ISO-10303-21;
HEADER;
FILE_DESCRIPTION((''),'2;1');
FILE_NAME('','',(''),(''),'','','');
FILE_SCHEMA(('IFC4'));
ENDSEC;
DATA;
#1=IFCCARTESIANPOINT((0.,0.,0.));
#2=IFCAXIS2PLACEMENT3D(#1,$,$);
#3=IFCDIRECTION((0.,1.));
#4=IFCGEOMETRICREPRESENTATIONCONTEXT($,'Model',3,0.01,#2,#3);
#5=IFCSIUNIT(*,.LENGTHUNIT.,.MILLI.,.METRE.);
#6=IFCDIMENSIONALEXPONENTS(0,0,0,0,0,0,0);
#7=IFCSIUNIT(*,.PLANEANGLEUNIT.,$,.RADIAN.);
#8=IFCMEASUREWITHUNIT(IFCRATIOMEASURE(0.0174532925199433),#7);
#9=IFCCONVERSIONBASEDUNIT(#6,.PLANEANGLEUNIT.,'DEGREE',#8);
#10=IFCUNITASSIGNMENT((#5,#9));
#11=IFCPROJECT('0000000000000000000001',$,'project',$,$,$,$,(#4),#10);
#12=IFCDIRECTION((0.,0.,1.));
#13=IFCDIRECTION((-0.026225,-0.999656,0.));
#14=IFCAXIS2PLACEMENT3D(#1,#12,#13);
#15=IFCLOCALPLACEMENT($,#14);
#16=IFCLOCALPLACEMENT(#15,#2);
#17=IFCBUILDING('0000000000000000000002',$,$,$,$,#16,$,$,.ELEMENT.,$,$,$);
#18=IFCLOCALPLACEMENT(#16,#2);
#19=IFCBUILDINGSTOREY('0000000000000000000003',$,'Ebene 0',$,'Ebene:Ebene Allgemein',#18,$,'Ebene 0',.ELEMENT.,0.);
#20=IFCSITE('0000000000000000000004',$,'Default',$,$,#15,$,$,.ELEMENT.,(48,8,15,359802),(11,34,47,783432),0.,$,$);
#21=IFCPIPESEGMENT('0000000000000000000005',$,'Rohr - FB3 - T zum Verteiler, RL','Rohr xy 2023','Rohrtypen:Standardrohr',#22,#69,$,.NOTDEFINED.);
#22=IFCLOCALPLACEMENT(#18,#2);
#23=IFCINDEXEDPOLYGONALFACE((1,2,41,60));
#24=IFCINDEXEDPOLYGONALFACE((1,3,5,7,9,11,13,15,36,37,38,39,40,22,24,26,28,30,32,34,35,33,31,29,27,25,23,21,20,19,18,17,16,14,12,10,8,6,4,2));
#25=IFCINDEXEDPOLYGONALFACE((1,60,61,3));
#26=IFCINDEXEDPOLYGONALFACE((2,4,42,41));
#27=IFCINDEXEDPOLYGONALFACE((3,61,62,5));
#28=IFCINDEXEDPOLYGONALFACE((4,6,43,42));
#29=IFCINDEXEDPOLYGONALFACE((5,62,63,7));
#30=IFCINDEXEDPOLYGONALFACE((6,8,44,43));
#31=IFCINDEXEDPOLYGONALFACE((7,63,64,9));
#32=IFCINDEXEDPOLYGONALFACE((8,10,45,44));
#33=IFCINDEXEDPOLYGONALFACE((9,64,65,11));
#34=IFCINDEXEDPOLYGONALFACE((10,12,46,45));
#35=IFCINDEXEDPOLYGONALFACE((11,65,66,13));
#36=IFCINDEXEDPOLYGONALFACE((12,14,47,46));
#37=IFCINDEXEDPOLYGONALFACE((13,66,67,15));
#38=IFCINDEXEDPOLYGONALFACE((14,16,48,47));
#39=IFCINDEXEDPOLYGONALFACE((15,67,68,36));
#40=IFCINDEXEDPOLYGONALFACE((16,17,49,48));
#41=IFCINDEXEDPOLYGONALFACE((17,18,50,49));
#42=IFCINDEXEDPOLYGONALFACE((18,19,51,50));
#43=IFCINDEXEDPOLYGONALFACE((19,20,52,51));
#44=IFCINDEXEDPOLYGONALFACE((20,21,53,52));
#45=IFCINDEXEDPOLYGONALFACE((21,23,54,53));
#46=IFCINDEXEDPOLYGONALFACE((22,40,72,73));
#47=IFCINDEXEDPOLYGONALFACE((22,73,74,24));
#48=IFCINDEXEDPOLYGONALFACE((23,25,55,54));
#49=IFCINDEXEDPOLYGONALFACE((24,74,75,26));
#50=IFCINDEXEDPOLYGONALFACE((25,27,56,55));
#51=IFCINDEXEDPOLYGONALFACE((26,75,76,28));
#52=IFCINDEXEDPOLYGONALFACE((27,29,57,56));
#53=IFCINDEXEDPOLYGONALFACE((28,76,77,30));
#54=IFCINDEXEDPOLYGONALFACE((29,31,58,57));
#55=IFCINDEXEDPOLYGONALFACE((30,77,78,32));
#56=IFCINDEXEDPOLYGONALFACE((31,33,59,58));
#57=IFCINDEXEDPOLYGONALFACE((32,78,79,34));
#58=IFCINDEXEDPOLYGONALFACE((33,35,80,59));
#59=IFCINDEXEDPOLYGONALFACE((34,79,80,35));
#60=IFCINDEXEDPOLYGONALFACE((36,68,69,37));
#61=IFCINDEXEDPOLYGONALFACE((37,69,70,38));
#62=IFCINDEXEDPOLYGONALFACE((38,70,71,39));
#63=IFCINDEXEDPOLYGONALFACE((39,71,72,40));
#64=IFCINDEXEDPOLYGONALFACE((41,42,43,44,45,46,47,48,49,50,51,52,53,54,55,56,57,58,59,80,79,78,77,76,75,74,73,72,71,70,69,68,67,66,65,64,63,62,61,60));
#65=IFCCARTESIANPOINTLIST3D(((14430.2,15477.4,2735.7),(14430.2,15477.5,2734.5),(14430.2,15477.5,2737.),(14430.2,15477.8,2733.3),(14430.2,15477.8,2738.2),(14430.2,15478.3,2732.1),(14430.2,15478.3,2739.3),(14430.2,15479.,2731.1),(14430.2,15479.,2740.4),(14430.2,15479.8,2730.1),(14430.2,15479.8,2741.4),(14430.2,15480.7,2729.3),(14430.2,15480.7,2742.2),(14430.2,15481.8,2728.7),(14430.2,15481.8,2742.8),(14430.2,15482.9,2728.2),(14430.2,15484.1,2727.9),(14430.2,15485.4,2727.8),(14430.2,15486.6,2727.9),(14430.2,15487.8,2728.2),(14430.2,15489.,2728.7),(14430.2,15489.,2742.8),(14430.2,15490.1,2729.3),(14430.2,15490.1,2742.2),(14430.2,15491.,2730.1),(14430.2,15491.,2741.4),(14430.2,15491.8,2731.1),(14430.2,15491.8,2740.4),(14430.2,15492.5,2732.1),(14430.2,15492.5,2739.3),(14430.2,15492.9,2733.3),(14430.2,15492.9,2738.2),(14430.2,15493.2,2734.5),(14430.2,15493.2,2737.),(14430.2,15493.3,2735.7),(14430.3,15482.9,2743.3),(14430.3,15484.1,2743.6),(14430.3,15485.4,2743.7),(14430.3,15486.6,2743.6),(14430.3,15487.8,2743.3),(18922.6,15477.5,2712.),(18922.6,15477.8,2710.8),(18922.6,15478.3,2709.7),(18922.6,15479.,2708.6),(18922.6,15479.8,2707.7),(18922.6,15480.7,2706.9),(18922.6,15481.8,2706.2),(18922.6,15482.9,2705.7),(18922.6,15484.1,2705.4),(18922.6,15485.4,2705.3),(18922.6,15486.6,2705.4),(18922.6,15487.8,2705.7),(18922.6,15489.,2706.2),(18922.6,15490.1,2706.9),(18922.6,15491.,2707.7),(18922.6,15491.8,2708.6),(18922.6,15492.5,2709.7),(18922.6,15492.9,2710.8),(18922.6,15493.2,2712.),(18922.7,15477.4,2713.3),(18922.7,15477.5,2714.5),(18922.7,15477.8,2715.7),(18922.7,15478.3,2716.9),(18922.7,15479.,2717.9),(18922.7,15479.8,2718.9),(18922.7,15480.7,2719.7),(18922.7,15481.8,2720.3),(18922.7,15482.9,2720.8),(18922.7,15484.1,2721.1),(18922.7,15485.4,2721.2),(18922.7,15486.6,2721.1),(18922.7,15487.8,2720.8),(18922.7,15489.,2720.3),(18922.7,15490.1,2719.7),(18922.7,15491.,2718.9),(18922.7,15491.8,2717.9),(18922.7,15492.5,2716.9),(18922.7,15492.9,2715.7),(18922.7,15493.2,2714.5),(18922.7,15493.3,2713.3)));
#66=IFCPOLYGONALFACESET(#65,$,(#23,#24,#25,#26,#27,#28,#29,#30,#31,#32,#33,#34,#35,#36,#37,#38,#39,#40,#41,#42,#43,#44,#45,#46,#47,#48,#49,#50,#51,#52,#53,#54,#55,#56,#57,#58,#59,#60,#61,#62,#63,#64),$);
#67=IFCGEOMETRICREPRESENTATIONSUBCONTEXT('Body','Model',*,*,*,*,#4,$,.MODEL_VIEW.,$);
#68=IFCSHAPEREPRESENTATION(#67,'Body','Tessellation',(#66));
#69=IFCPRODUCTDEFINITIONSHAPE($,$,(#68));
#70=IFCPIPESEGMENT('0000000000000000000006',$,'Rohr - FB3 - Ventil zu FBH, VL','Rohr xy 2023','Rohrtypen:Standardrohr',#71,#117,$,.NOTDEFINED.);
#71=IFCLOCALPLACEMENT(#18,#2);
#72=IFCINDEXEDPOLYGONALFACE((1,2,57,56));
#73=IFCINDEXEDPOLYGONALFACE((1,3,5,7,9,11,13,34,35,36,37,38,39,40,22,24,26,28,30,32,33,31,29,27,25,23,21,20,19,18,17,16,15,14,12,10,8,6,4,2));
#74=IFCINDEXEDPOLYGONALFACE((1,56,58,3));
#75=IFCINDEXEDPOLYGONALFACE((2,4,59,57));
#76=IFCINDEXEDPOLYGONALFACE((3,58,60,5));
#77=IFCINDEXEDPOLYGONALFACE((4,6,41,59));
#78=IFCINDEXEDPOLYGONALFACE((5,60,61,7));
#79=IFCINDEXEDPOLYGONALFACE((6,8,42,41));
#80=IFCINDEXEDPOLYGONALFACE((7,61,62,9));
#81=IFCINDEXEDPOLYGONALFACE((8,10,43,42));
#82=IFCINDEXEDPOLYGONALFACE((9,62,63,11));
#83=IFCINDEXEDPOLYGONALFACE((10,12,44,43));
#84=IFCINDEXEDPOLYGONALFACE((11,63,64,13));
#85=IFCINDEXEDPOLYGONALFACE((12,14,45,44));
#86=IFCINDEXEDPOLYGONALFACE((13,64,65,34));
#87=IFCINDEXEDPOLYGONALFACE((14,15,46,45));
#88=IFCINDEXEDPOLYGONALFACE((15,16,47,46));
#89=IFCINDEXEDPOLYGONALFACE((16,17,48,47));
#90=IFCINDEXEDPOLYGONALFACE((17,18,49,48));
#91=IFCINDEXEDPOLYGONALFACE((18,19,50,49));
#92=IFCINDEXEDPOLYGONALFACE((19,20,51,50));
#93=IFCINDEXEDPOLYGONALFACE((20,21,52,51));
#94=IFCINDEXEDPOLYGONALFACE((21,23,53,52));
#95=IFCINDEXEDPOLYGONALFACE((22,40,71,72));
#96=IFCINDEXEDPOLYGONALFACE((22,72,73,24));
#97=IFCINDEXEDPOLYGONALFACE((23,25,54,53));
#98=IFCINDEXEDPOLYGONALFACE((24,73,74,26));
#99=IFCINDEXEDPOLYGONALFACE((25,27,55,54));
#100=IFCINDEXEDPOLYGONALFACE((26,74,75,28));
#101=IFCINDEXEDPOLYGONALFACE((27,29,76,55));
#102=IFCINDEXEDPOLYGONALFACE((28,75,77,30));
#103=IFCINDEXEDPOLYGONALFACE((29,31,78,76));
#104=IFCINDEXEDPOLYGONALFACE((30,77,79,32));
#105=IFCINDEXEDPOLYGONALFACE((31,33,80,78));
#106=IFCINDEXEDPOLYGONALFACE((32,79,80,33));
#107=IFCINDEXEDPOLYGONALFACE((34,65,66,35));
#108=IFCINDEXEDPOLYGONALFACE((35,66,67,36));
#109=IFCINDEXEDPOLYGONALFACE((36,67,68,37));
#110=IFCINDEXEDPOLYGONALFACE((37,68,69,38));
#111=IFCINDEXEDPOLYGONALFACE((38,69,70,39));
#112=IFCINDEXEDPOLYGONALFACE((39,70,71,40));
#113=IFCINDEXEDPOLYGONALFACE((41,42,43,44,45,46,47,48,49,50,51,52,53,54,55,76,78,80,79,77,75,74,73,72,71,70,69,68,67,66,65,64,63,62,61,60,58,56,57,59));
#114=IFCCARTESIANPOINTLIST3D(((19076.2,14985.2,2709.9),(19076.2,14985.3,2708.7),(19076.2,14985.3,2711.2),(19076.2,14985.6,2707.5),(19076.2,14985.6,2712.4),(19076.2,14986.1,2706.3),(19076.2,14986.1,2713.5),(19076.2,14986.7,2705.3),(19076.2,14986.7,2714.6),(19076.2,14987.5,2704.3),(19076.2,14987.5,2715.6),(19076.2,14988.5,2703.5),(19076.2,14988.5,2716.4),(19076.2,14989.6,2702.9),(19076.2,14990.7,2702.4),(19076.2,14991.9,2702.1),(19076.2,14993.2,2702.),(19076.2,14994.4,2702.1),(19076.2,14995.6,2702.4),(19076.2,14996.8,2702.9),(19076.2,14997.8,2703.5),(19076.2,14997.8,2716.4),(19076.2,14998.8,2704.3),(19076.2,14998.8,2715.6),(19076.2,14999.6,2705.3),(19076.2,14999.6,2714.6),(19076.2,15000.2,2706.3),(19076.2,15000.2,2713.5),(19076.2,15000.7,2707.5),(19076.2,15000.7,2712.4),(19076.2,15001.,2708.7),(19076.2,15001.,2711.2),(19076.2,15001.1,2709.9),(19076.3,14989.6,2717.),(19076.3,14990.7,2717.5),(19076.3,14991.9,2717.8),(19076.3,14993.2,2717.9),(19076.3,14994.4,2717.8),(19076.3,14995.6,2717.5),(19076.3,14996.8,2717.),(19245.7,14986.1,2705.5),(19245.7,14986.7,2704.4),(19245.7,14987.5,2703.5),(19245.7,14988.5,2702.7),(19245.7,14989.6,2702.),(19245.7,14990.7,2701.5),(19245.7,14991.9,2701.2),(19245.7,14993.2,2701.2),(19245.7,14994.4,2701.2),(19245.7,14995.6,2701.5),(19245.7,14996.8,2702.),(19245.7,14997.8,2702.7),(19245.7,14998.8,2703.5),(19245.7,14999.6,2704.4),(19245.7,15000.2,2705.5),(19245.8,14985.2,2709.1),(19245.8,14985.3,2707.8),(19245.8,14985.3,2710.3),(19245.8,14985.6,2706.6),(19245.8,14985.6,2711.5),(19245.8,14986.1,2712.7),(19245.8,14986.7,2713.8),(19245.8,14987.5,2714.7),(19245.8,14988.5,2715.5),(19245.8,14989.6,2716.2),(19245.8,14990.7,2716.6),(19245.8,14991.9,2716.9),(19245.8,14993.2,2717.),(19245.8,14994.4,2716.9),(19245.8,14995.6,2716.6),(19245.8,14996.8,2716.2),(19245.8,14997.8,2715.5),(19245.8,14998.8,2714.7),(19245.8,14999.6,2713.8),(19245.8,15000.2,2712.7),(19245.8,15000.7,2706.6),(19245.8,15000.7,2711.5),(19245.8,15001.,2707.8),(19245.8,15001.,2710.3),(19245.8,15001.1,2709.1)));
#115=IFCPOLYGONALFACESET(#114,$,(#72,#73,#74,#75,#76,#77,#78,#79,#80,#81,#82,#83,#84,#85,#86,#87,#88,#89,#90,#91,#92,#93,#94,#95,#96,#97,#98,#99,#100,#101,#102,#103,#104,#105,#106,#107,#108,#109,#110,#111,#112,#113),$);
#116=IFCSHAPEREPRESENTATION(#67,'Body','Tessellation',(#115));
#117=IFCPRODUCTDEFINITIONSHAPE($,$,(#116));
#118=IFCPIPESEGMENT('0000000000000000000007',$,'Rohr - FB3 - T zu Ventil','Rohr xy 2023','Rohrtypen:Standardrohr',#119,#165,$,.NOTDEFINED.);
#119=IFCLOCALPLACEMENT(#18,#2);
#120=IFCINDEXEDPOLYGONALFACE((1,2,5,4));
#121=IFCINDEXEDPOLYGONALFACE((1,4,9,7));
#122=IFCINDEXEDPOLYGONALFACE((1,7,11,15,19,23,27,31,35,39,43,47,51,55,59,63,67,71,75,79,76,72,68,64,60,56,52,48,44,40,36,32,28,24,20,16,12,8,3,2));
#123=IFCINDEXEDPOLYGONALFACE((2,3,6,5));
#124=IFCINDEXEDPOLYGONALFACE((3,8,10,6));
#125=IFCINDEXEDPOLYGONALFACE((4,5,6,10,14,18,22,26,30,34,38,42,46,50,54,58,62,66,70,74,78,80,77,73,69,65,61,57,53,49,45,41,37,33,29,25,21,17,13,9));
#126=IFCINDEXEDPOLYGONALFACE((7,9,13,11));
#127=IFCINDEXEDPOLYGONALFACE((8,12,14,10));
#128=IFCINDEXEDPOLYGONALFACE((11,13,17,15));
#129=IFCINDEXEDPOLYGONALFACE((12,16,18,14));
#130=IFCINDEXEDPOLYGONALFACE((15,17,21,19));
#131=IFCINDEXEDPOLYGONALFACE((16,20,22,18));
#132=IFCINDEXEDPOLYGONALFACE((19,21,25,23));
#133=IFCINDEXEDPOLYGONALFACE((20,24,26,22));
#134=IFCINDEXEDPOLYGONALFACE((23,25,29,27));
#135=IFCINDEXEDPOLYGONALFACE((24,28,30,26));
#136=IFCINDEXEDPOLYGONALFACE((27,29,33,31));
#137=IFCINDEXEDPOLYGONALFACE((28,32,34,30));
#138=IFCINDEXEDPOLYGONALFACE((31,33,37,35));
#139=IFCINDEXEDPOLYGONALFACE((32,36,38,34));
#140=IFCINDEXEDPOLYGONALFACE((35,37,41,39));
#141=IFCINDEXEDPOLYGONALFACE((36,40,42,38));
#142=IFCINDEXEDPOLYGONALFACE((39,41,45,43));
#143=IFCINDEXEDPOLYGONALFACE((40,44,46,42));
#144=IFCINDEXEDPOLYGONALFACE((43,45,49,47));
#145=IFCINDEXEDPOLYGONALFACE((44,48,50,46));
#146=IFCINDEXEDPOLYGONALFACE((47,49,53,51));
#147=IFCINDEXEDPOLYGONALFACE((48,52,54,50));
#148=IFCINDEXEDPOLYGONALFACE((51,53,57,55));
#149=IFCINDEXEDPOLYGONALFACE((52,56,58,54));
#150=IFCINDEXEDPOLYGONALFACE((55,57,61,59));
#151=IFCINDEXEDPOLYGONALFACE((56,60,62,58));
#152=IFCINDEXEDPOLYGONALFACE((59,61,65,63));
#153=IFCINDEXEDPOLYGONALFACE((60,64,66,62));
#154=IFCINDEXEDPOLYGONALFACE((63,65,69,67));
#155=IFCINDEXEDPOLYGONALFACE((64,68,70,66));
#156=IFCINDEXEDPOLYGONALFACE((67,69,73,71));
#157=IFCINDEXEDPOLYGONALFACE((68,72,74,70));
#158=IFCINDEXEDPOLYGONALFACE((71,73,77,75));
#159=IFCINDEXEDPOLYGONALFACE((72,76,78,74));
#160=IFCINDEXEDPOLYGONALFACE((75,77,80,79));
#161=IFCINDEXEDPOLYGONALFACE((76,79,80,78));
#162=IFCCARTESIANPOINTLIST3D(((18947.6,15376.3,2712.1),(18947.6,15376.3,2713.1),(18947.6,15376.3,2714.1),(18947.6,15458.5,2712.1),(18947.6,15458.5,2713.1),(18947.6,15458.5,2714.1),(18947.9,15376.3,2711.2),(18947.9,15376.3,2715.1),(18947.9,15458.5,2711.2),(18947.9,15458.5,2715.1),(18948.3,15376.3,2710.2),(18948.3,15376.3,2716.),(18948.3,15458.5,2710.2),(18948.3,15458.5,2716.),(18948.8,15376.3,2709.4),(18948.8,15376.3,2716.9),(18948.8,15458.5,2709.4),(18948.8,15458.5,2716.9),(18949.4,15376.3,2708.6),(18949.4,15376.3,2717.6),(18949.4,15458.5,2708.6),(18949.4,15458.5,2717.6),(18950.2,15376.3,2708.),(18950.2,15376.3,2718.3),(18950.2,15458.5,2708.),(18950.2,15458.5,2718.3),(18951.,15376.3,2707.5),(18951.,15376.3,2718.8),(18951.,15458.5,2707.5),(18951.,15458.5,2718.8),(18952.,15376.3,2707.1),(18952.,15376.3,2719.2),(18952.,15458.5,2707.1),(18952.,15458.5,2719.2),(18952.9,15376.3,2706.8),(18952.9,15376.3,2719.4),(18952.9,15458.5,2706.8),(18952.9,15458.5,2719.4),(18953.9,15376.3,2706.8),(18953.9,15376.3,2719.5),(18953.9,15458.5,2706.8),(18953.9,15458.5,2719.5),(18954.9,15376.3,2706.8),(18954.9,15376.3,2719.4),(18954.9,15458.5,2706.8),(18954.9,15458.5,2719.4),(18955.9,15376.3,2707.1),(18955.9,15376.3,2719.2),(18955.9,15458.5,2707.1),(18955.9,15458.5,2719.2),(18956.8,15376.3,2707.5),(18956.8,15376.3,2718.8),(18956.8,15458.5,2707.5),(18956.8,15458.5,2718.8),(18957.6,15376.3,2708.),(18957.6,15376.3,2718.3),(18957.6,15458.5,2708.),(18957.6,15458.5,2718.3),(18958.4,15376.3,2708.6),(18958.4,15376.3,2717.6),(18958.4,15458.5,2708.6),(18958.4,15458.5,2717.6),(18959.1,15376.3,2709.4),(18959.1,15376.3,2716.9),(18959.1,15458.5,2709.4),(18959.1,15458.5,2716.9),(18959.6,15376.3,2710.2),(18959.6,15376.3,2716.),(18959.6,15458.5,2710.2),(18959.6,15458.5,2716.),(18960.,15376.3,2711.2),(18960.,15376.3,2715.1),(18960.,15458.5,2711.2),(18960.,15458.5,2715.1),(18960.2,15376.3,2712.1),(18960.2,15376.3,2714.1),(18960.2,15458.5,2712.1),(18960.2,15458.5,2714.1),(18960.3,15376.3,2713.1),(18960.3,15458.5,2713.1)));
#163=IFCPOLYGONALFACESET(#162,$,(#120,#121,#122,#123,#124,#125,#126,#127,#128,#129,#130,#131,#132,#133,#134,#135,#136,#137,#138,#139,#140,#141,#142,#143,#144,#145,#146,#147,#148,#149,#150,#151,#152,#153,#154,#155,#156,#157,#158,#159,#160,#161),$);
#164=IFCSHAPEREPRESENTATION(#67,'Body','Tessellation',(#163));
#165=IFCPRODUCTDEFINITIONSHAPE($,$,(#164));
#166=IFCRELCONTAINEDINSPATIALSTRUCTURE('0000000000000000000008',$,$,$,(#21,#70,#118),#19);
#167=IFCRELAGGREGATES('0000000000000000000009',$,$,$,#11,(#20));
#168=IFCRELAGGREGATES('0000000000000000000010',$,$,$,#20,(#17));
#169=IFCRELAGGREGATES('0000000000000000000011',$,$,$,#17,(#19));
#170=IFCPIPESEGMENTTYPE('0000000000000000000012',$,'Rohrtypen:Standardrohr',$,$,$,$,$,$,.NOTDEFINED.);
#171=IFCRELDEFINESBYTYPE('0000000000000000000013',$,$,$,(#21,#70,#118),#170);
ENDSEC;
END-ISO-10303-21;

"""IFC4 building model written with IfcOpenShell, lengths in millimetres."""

from ifc_helpers import new_model, entity, si_unit, converted_unit, direction, frame, origin, place, context, subcontext, project, spatial, indexed_curve, outline, extrude, type_object, element, save


model = new_model("IFC4")

# Units and contexts
model_context = context("Model", 3, precision=0.01, world=origin(), true_north=direction((0.0, 1.0)))
body_context = subcontext(model_context, "Body", "Model", "MODEL_VIEW")
ifc_project = project(units=[si_unit("LENGTHUNIT", "METRE", prefix="MILLI"), converted_unit("PLANEANGLEUNIT", "DEGREE", entity("IfcRatioMeasure", 0.0174532925199433), si_unit("PLANEANGLEUNIT", "RADIAN"), dimensions=[0, 0, 0, 0, 0, 0, 0])], contexts=[model_context])

# Site, building, storey
site_placement = place(None, frame((0.0, 0.0, 0.0), z_axis=(0.0, 0.0, 1.0), x_axis=(-0.026225, -0.999656, 0.0)))
site = spatial("IfcSite", under=ifc_project, at=site_placement, Name="Default", CompositionType="ELEMENT", RefLatitude=(48, 8, 15, 359802), RefLongitude=(11, 34, 47, 783432), RefElevation=0.0)
building_placement = place(site_placement, origin())
building = spatial("IfcBuilding", under=site, at=building_placement, CompositionType="ELEMENT")
storey_placement = place(building_placement, origin())
storey = spatial("IfcBuildingStorey", under=building, at=storey_placement, Name="Ebene 0", ObjectType="Ebene:Ebene Allgemein", LongName="Ebene 0", CompositionType="ELEMENT", Elevation=0.0)

# Pipe segments
pipe_segment_type = type_object("IfcPipeSegmentType", Name="Rohrtypen:Standardrohr", PredefinedType="NOTDEFINED")
pipe_segment_1_placement = place(storey_placement, origin())
element("IfcPipeSegment", 1, at=pipe_segment_1_placement, inside=storey, type_object=pipe_segment_type, Name="Rohr - FB3 - T zum Verteiler, RL", Description="Rohr xy 2023", ObjectType="Rohrtypen:Standardrohr", PredefinedType="NOTDEFINED", context=body_context, shape_type="SweptSolid", body=[
    extrude(outline(indexed_curve([(7.9, 0.0), (7.8, 1.2), (7.6, 2.5), (7.1, 3.6), (6.4, 4.7), (5.6, 5.6), (4.7, 6.4), (3.6, 7.1), (2.5, 7.6), (1.2, 7.8), (0.0, 7.9), (-1.2, 7.8), (-2.5, 7.6), (-3.6, 7.1), (-4.7, 6.4), (-5.6, 5.6), (-6.4, 4.7), (-7.1, 3.6), (-7.6, 2.5), (-7.8, 1.2), (-7.9, 0.0), (-7.8, -1.2), (-7.6, -2.5), (-7.1, -3.6), (-6.4, -4.7), (-5.6, -5.6), (-4.7, -6.4), (-3.6, -7.1), (-2.5, -7.6), (-1.2, -7.8), (0.0, -7.9), (1.2, -7.8), (2.5, -7.6), (3.6, -7.1), (4.7, -6.4), (5.6, -5.6), (6.4, -4.7), (7.1, -3.6), (7.6, -2.5), (7.8, -1.2), (7.9, 0.0)], self_intersect=False)), frame((14430.2, 15485.4, 2735.7), z_axis=(0.999988, 0.0, -0.005), x_axis=(0.0, 1.0, 0.0)), (0.0, 0.0, 1.0), 4492.5),
])
pipe_segment_2_placement = place(storey_placement, origin())
element("IfcPipeSegment", 2, at=pipe_segment_2_placement, inside=storey, type_object=pipe_segment_type, Name="Rohr - FB3 - Ventil zu FBH, VL", Description="Rohr xy 2023", ObjectType="Rohrtypen:Standardrohr", PredefinedType="NOTDEFINED", context=body_context, shape_type="SweptSolid", body=[
    extrude(outline(indexed_curve([(7.9, 0.0), (7.8, 1.2), (7.6, 2.5), (7.1, 3.6), (6.4, 4.7), (5.6, 5.6), (4.7, 6.4), (3.6, 7.1), (2.5, 7.6), (1.2, 7.8), (0.0, 7.9), (-1.2, 7.8), (-2.5, 7.6), (-3.6, 7.1), (-4.7, 6.4), (-5.6, 5.6), (-6.4, 4.7), (-7.1, 3.6), (-7.6, 2.5), (-7.8, 1.2), (-7.9, 0.0), (-7.8, -1.2), (-7.6, -2.5), (-7.1, -3.6), (-6.4, -4.7), (-5.6, -5.6), (-4.7, -6.4), (-3.6, -7.1), (-2.5, -7.6), (-1.2, -7.8), (0.0, -7.9), (1.2, -7.8), (2.5, -7.6), (3.6, -7.1), (4.7, -6.4), (5.6, -5.6), (6.4, -4.7), (7.1, -3.6), (7.6, -2.5), (7.8, -1.2), (7.9, 0.0)], self_intersect=False)), frame((19076.2, 14993.2, 2709.9), z_axis=(0.999988, 0.0, -0.005), x_axis=(0.0, 1.0, 0.0)), (0.0, 0.0, 1.0), 169.5),
])
pipe_segment_3_placement = place(storey_placement, origin())
element("IfcPipeSegment", 3, at=pipe_segment_3_placement, inside=storey, type_object=pipe_segment_type, Name="Rohr - FB3 - T zu Ventil", Description="Rohr xy 2023", ObjectType="Rohrtypen:Standardrohr", PredefinedType="NOTDEFINED", context=body_context, shape_type="SweptSolid", body=[
    extrude(outline(indexed_curve([(6.4, 0.0), (6.3, 1.0), (6.0, 2.0), (5.7, 2.9), (5.1, 3.7), (4.5, 4.5), (3.7, 5.1), (2.9, 5.7), (2.0, 6.0), (1.0, 6.3), (0.0, 6.4), (-1.0, 6.3), (-2.0, 6.0), (-2.9, 5.7), (-3.7, 5.1), (-4.5, 4.5), (-5.1, 3.7), (-5.7, 2.9), (-6.0, 2.0), (-6.3, 1.0), (-6.4, 0.0), (-6.3, -1.0), (-6.0, -2.0), (-5.7, -2.9), (-5.1, -3.7), (-4.5, -4.5), (-3.7, -5.1), (-2.9, -5.7), (-2.0, -6.0), (-1.0, -6.3), (0.0, -6.4), (1.0, -6.3), (2.0, -6.0), (2.9, -5.7), (3.7, -5.1), (4.5, -4.5), (5.1, -3.7), (5.7, -2.9), (6.0, -2.0), (6.3, -1.0), (6.4, 0.0)], self_intersect=False)), frame((18953.9, 15376.3, 2713.1), z_axis=(0.0, 1.0, 0.0), x_axis=(-1.0, 0.0, 0.0)), (0.0, 0.0, 1.0), 82.2),
])

save(model, "model.ifc")
